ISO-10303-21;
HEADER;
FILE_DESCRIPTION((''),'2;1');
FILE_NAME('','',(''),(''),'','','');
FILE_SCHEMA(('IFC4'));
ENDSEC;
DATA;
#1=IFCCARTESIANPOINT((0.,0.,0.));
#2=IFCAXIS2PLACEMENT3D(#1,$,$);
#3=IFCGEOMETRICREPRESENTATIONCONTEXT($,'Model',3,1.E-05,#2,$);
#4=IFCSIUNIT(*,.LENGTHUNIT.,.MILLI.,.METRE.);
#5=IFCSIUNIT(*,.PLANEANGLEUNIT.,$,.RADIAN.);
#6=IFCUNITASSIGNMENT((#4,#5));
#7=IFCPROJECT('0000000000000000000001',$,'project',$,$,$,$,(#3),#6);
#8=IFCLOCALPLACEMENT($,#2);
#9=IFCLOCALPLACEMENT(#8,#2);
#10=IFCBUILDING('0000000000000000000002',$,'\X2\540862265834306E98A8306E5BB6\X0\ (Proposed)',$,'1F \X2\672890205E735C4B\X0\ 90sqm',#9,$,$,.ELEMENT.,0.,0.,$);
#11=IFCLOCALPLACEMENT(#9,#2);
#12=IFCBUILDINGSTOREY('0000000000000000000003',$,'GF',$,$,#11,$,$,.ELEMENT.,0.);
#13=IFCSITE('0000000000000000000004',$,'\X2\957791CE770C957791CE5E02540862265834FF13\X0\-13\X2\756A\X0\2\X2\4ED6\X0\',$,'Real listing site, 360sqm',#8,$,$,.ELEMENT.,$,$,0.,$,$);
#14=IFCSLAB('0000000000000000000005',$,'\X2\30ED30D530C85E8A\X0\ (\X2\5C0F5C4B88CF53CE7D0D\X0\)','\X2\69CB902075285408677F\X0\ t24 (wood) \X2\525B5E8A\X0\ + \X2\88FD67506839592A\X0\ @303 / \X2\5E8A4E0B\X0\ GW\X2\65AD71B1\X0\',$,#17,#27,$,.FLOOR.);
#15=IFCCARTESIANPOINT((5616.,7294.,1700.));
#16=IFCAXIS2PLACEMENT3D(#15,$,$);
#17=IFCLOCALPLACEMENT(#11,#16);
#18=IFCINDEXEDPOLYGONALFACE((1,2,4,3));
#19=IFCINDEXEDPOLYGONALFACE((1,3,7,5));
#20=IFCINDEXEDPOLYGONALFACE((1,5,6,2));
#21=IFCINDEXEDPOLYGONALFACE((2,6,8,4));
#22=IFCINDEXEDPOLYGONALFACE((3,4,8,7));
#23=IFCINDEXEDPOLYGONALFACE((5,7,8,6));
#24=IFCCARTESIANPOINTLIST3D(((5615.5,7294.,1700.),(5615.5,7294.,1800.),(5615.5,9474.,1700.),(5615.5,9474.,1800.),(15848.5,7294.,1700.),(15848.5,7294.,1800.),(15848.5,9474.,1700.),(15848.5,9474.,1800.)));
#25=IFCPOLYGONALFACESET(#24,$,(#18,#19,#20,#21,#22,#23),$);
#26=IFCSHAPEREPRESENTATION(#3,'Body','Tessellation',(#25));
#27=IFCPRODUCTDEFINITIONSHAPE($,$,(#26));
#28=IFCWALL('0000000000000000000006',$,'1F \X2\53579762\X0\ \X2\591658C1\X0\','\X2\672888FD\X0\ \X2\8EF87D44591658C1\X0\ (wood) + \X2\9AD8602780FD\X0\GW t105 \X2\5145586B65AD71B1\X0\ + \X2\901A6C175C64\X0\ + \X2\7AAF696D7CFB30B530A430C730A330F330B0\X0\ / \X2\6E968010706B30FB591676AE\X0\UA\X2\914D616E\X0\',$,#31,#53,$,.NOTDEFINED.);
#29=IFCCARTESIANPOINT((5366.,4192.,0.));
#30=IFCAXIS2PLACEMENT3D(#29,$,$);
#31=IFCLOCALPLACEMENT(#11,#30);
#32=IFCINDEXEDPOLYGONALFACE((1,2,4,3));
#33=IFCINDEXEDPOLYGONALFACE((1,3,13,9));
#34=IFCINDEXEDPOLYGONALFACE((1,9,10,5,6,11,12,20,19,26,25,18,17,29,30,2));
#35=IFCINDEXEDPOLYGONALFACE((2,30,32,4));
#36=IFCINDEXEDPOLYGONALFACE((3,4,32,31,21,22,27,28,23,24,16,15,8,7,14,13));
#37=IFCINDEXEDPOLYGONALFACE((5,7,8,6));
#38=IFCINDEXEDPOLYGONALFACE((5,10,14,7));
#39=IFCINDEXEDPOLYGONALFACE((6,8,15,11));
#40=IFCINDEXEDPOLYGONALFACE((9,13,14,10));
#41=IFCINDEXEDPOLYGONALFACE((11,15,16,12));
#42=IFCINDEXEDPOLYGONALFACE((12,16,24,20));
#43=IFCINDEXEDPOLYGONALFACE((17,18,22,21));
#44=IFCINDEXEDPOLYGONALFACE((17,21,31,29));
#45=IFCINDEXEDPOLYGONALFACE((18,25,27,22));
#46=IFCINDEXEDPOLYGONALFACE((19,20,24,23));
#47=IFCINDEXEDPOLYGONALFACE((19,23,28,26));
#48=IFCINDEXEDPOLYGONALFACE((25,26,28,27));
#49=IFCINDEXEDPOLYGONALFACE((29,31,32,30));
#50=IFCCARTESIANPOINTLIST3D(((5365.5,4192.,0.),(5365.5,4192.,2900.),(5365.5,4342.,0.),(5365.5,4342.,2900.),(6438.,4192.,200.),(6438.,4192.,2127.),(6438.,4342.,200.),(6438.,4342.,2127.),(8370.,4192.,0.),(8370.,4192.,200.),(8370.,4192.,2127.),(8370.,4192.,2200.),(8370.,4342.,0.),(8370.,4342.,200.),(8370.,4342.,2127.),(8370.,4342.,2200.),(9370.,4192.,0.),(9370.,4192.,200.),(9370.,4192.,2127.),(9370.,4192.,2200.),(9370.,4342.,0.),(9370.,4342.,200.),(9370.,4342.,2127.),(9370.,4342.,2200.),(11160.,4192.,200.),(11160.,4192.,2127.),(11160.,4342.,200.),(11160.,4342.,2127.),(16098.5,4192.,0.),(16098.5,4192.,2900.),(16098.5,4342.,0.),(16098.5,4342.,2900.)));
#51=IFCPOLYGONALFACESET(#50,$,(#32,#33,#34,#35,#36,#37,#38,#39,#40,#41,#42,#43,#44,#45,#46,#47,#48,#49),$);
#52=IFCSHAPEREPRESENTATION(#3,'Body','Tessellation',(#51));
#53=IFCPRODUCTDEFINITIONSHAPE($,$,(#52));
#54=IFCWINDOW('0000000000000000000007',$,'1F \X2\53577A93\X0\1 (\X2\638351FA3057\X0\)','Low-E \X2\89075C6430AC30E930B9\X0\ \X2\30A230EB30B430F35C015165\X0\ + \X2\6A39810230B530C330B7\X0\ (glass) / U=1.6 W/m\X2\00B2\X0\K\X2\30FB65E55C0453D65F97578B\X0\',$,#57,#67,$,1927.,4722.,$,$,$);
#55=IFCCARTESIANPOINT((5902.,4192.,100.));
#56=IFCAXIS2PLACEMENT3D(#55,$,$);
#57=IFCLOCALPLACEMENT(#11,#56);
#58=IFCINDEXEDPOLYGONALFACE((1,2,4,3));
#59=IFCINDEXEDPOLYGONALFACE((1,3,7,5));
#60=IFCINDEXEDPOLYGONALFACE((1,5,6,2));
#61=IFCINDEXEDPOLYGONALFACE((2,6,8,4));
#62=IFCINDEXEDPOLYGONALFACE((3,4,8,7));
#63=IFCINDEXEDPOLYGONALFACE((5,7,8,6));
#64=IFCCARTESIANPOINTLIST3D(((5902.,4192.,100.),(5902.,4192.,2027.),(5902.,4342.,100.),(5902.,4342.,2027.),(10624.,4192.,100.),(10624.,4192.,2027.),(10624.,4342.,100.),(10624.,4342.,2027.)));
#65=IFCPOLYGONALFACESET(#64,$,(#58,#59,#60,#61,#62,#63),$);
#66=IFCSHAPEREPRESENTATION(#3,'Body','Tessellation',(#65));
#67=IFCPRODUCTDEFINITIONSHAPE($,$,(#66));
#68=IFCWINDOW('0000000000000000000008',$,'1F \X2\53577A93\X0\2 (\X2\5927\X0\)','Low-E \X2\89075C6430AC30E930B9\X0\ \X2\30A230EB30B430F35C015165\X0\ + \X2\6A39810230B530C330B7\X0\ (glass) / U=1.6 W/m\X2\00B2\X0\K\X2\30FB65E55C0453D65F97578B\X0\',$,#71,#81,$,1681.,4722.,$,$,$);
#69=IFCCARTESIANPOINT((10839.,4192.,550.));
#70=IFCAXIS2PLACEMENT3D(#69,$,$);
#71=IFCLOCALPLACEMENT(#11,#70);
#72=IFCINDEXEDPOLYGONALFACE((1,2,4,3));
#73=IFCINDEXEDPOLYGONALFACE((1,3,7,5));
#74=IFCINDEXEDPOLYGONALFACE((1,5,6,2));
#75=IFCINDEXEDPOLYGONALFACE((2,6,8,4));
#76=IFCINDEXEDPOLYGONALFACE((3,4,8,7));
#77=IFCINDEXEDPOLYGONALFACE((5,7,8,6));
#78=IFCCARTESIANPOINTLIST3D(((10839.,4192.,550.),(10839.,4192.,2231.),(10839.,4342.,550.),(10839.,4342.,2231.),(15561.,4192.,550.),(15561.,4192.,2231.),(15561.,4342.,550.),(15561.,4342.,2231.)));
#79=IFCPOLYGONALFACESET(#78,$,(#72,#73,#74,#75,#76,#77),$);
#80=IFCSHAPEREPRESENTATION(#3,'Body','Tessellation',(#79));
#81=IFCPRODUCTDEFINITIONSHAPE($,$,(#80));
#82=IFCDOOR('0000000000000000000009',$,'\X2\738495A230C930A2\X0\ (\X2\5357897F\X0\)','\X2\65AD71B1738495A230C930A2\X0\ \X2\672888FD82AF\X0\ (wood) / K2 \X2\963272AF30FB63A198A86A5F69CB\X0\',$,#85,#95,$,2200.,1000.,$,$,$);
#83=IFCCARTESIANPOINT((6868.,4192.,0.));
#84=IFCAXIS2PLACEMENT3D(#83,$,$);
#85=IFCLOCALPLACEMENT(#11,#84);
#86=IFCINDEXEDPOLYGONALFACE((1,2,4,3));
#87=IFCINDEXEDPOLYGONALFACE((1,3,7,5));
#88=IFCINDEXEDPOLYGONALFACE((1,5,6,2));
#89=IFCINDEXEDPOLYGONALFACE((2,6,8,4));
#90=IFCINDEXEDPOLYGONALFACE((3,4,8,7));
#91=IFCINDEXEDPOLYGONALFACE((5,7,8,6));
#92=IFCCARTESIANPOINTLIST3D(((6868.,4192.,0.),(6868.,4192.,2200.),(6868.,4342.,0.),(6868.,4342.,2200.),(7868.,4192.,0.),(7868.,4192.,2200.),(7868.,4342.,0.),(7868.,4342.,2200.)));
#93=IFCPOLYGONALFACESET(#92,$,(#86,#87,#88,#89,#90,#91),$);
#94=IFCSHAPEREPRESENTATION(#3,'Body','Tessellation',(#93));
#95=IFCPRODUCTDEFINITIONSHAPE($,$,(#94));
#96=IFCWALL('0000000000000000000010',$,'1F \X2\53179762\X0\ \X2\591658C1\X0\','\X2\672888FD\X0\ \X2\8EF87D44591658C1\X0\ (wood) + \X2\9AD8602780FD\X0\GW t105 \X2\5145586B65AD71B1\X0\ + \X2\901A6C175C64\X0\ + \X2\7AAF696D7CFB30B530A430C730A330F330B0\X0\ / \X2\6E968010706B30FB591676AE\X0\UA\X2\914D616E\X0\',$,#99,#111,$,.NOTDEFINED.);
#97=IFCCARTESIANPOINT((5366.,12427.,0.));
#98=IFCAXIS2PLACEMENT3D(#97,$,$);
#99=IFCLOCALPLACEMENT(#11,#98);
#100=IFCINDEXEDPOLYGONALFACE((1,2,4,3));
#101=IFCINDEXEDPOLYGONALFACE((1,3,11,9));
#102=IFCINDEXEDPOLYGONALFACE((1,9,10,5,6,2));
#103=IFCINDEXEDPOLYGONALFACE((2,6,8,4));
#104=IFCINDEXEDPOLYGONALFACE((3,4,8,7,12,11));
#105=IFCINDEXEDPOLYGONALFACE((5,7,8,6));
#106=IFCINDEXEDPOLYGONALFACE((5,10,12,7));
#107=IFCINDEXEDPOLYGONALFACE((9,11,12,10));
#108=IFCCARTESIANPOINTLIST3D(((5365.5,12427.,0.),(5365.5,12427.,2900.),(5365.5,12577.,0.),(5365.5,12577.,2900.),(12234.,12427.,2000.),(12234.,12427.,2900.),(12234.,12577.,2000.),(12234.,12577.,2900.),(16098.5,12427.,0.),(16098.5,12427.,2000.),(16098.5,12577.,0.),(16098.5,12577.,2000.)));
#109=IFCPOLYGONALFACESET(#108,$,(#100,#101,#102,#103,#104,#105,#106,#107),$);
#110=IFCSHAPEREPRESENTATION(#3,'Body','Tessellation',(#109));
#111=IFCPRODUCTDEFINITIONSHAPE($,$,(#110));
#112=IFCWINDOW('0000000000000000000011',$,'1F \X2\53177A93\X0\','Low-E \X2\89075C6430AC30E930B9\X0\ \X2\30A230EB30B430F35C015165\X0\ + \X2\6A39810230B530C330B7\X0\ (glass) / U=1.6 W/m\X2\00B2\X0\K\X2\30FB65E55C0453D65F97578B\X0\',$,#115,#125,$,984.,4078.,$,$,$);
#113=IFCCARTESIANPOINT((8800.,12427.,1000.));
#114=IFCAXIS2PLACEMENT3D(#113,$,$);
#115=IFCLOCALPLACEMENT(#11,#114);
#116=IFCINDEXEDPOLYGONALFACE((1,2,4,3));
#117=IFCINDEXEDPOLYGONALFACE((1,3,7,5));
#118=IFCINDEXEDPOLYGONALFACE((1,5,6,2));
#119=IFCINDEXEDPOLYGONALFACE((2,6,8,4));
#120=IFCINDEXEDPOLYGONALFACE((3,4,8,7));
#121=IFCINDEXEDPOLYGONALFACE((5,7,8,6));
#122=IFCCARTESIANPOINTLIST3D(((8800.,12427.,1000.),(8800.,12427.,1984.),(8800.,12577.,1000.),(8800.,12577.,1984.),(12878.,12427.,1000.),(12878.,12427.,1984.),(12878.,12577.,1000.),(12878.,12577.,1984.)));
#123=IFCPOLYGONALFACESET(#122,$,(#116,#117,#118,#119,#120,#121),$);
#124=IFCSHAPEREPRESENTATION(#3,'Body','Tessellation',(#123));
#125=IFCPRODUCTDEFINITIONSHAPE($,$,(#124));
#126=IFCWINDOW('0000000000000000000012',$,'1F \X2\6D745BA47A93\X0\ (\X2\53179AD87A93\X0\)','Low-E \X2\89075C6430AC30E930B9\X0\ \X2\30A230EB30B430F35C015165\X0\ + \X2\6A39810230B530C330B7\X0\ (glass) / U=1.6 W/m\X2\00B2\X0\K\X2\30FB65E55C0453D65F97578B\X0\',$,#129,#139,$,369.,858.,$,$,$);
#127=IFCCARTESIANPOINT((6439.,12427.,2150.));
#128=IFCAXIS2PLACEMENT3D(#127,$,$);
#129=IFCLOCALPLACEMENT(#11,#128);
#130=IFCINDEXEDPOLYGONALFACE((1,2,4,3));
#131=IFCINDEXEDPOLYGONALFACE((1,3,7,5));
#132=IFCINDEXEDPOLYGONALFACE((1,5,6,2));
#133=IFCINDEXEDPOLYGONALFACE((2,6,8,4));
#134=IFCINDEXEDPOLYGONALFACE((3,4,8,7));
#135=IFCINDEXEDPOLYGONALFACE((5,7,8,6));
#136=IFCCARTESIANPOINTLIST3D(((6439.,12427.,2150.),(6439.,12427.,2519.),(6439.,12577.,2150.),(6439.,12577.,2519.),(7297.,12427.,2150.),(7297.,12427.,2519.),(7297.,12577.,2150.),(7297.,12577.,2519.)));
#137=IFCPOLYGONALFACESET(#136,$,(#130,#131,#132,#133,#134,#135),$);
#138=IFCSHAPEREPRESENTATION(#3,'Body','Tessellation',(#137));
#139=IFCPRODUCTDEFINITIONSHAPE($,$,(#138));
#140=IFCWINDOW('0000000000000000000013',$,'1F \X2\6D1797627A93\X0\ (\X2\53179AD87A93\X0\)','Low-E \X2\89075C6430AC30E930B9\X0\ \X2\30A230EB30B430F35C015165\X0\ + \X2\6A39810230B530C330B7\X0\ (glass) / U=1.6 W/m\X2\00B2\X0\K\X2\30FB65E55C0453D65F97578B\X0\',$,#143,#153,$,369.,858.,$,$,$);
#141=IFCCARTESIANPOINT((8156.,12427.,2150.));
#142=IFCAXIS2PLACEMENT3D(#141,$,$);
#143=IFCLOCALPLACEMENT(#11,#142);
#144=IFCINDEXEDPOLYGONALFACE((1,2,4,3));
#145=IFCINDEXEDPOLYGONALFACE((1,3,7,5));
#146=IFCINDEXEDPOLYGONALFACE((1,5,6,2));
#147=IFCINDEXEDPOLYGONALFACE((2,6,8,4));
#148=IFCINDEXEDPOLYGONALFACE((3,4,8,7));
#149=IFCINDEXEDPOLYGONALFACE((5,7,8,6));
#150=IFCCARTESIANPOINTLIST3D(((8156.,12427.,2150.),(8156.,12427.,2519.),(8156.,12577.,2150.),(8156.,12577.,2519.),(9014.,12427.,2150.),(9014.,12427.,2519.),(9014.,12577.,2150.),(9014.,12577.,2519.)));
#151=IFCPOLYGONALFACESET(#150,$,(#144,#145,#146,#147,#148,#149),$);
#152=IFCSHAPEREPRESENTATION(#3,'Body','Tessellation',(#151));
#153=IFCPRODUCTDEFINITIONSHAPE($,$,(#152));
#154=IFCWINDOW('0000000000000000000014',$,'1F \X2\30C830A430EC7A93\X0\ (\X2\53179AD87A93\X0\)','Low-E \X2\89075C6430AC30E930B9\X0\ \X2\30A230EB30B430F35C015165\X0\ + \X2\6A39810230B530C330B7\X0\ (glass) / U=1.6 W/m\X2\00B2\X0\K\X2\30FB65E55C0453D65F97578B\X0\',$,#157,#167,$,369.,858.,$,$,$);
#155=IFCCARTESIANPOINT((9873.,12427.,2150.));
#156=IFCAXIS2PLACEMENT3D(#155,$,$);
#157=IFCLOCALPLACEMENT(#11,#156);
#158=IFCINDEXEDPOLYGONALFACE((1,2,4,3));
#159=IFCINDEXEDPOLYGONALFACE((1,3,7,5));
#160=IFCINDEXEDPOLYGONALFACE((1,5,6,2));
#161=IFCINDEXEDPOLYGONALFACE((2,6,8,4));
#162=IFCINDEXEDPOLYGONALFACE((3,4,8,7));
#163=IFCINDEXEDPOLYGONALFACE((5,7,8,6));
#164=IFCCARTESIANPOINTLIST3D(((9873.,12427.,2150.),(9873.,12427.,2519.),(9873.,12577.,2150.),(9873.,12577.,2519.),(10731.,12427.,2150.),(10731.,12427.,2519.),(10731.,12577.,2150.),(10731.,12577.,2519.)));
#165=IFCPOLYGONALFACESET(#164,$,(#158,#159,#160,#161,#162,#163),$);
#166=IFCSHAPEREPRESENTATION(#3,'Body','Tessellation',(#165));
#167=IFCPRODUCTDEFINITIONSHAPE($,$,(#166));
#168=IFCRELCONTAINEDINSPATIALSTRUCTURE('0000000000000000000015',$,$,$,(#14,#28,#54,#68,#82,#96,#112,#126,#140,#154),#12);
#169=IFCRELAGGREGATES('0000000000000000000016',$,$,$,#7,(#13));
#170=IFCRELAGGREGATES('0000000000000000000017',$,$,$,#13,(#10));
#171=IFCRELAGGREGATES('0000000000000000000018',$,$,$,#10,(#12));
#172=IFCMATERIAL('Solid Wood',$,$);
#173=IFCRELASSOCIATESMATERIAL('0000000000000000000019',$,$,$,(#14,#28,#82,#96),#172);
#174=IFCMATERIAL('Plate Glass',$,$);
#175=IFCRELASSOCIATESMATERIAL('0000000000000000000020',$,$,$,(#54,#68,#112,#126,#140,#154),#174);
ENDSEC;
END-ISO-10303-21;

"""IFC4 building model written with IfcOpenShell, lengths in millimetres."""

from ifc_helpers import new_model, si_unit, frame, frame_2d, origin, place, context, project, spatial, rectangle, extrude, material, element, fill, save


model = new_model("IFC4")

# Units and contexts
model_context = context("Model", 3, precision=1e-05, world=origin())
ifc_project = project(units=[si_unit("LENGTHUNIT", "METRE", prefix="MILLI"), si_unit("PLANEANGLEUNIT", "RADIAN")], contexts=[model_context])

# Site, building, storey
site_placement = place(None, origin())
site = spatial("IfcSite", under=ifc_project, at=site_placement, Name="長野県長野市合戦場３-13番2他", ObjectType="Real listing site, 360sqm", CompositionType="ELEMENT", RefElevation=0.0)
building_placement = place(site_placement, origin())
building = spatial("IfcBuilding", under=site, at=building_placement, Name="合戦場の風の家 (Proposed)", ObjectType="1F 木造平屋 90sqm", CompositionType="ELEMENT", ElevationOfRefHeight=0.0, ElevationOfTerrain=0.0)
storey_placement = place(building_placement, origin())
storey = spatial("IfcBuildingStorey", under=building, at=storey_placement, Name="GF", CompositionType="ELEMENT", Elevation=0.0)

# Slab
ifc_material_1 = material(Name="Solid Wood")
slab_1_placement = place(storey_placement, frame((5616.0, 7294.0, 1700.0)))
element("IfcSlab", 1, at=slab_1_placement, inside=storey, material=ifc_material_1, Name="ロフト床 (小屋裏収納)", Description="構造用合板 t24 (wood) 剛床 + 製材根太 @303 / 床下 GW断熱", PredefinedType="FLOOR", context=model_context, shape_type="SweptSolid", body=[
    extrude(rectangle(XDim=10233.0, YDim=2180.0, at=frame_2d((5116.0, 1090.0))), frame((5616.0, 7294.0, 1700.0)), (0.0, 0.0, 1.0), 100.0),
])

# Wall, openings, windows, door
wall_1_placement = place(storey_placement, frame((5366.0, 4192.0, 0.0)))
wall_1 = element("IfcWall", 2, at=wall_1_placement, inside=storey, material=ifc_material_1, Name="1F 南面 外壁", Description="木製 軸組外壁 (wood) + 高性能GW t105 充填断熱 + 通気層 + 窯業系サイディング / 準耐火・外皮UA配慮", PredefinedType="NOTDEFINED", context=model_context, shape_type="SweptSolid", body=[
    extrude(rectangle(XDim=10733.0, YDim=150.0, at=frame_2d((5366.0, 75.0))), frame((5366.0, 4192.0, 0.0)), (0.0, 0.0, 1.0), 2900.0),
])
opening_1_placement = place(storey_placement, frame((5902.0, 4192.0, 100.0)))
opening_1 = element("IfcOpeningElement", 3, at=opening_1_placement, cuts=wall_1, PredefinedType="NOTDEFINED", context=model_context, shape_type="SweptSolid", body=[
    extrude(rectangle(XDim=4722.0, YDim=150.0, at=frame_2d((2361.0, 75.0))), frame((5902.0, 4192.0, 100.0)), (0.0, 0.0, 1.0), 1927.0),
])
opening_2_placement = place(storey_placement, frame((10839.0, 4192.0, 550.0)))
opening_2 = element("IfcOpeningElement", 4, at=opening_2_placement, cuts=wall_1, PredefinedType="NOTDEFINED", context=model_context, shape_type="SweptSolid", body=[
    extrude(rectangle(XDim=4722.0, YDim=150.0, at=frame_2d((2361.0, 75.0))), frame((10839.0, 4192.0, 550.0)), (0.0, 0.0, 1.0), 1681.0),
])
opening_3_placement = place(storey_placement, frame((6868.0, 4192.0, 0.0)))
opening_3 = element("IfcOpeningElement", 5, at=opening_3_placement, cuts=wall_1, PredefinedType="NOTDEFINED", context=model_context, shape_type="SweptSolid", body=[
    extrude(rectangle(XDim=1000.0, YDim=150.0, at=frame_2d((500.0, 75.0))), frame((6868.0, 4192.0, 0.0)), (0.0, 0.0, 1.0), 2200.0),
])
ifc_material_2 = material(Name="Plate Glass")
window_1_placement = place(storey_placement, frame((5902.0, 4192.0, 100.0)))
window_1 = element("IfcWindow", 6, at=window_1_placement, inside=storey, material=ifc_material_2, Name="1F 南窓1 (掃出し)", Description="Low-E 複層ガラス アルゴン封入 + 樹脂サッシ (glass) / U=1.6 W/m²K・日射取得型", OverallHeight=1927.0, OverallWidth=4722.0, context=model_context, shape_type="SweptSolid", body=[
    extrude(rectangle(XDim=4722.0, YDim=150.0, at=frame_2d((2361.0, 75.0))), frame((5902.0, 4192.0, 100.0)), (0.0, 0.0, 1.0), 1927.0),
])
fill(opening_1, window_1)
window_2_placement = place(storey_placement, frame((10839.0, 4192.0, 550.0)))
window_2 = element("IfcWindow", 7, at=window_2_placement, inside=storey, material=ifc_material_2, Name="1F 南窓2 (大)", Description="Low-E 複層ガラス アルゴン封入 + 樹脂サッシ (glass) / U=1.6 W/m²K・日射取得型", OverallHeight=1681.0, OverallWidth=4722.0, context=model_context, shape_type="SweptSolid", body=[
    extrude(rectangle(XDim=4722.0, YDim=150.0, at=frame_2d((2361.0, 75.0))), frame((10839.0, 4192.0, 550.0)), (0.0, 0.0, 1.0), 1681.0),
])
fill(opening_2, window_2)
door_1_placement = place(storey_placement, frame((6868.0, 4192.0, 0.0)))
door_1 = element("IfcDoor", 8, at=door_1_placement, inside=storey, material=ifc_material_1, Name="玄関ドア (南西)", Description="断熱玄関ドア 木製芯 (wood) / K2 防犯・採風機構", OverallHeight=2200.0, OverallWidth=1000.0, context=model_context, shape_type="SweptSolid", body=[
    extrude(rectangle(XDim=1000.0, YDim=150.0, at=frame_2d((500.0, 75.0))), frame((6868.0, 4192.0, 0.0)), (0.0, 0.0, 1.0), 2200.0),
])
fill(opening_3, door_1)

# Wall, openings, windows
wall_2_placement = place(storey_placement, frame((5366.0, 12427.0, 0.0)))
wall_2 = element("IfcWall", 9, at=wall_2_placement, inside=storey, material=ifc_material_1, Name="1F 北面 外壁", Description="木製 軸組外壁 (wood) + 高性能GW t105 充填断熱 + 通気層 + 窯業系サイディング / 準耐火・外皮UA配慮", PredefinedType="NOTDEFINED", context=model_context, shape_type="SweptSolid", body=[
    extrude(rectangle(XDim=10733.0, YDim=150.0, at=frame_2d((5366.0, 75.0))), frame((5366.0, 12427.0, 0.0)), (0.0, 0.0, 1.0), 2900.0),
])
opening_4_placement = place(storey_placement, frame((8800.0, 12427.0, 1000.0)))
opening_4 = element("IfcOpeningElement", 10, at=opening_4_placement, cuts=wall_2, PredefinedType="NOTDEFINED", context=model_context, shape_type="SweptSolid", body=[
    extrude(rectangle(XDim=4078.0, YDim=150.0, at=frame_2d((2039.0, 75.0))), frame((8800.0, 12427.0, 1000.0)), (0.0, 0.0, 1.0), 984.0),
])
opening_5_placement = place(storey_placement, frame((6439.0, 12427.0, 2150.0)))
opening_5 = element("IfcOpeningElement", 11, at=opening_5_placement, cuts=wall_2, PredefinedType="NOTDEFINED", context=model_context, shape_type="SweptSolid", body=[
    extrude(rectangle(XDim=858.0, YDim=150.0, at=frame_2d((429.0, 75.0))), frame((6439.0, 12427.0, 2150.0)), (0.0, 0.0, 1.0), 369.0),
])
opening_6_placement = place(storey_placement, frame((8156.0, 12427.0, 2150.0)))
opening_6 = element("IfcOpeningElement", 12, at=opening_6_placement, cuts=wall_2, PredefinedType="NOTDEFINED", context=model_context, shape_type="SweptSolid", body=[
    extrude(rectangle(XDim=858.0, YDim=150.0, at=frame_2d((429.0, 75.0))), frame((8156.0, 12427.0, 2150.0)), (0.0, 0.0, 1.0), 369.0),
])
opening_7_placement = place(storey_placement, frame((9873.0, 12427.0, 2150.0)))
opening_7 = element("IfcOpeningElement", 13, at=opening_7_placement, cuts=wall_2, PredefinedType="NOTDEFINED", context=model_context, shape_type="SweptSolid", body=[
    extrude(rectangle(XDim=858.0, YDim=150.0, at=frame_2d((429.0, 75.0))), frame((9873.0, 12427.0, 2150.0)), (0.0, 0.0, 1.0), 369.0),
])
window_3_placement = place(storey_placement, frame((8800.0, 12427.0, 1000.0)))
window_3 = element("IfcWindow", 14, at=window_3_placement, inside=storey, material=ifc_material_2, Name="1F 北窓", Description="Low-E 複層ガラス アルゴン封入 + 樹脂サッシ (glass) / U=1.6 W/m²K・日射取得型", OverallHeight=984.0, OverallWidth=4078.0, context=model_context, shape_type="SweptSolid", body=[
    extrude(rectangle(XDim=4078.0, YDim=150.0, at=frame_2d((2039.0, 75.0))), frame((8800.0, 12427.0, 1000.0)), (0.0, 0.0, 1.0), 984.0),
])
fill(opening_4, window_3)
window_4_placement = place(storey_placement, frame((6439.0, 12427.0, 2150.0)))
window_4 = element("IfcWindow", 15, at=window_4_placement, inside=storey, material=ifc_material_2, Name="1F 浴室窓 (北高窓)", Description="Low-E 複層ガラス アルゴン封入 + 樹脂サッシ (glass) / U=1.6 W/m²K・日射取得型", OverallHeight=369.0, OverallWidth=858.0, context=model_context, shape_type="SweptSolid", body=[
    extrude(rectangle(XDim=858.0, YDim=150.0, at=frame_2d((429.0, 75.0))), frame((6439.0, 12427.0, 2150.0)), (0.0, 0.0, 1.0), 369.0),
])
fill(opening_5, window_4)
window_5_placement = place(storey_placement, frame((8156.0, 12427.0, 2150.0)))
window_5 = element("IfcWindow", 16, at=window_5_placement, inside=storey, material=ifc_material_2, Name="1F 洗面窓 (北高窓)", Description="Low-E 複層ガラス アルゴン封入 + 樹脂サッシ (glass) / U=1.6 W/m²K・日射取得型", OverallHeight=369.0, OverallWidth=858.0, context=model_context, shape_type="SweptSolid", body=[
    extrude(rectangle(XDim=858.0, YDim=150.0, at=frame_2d((429.0, 75.0))), frame((8156.0, 12427.0, 2150.0)), (0.0, 0.0, 1.0), 369.0),
])
fill(opening_6, window_5)
window_6_placement = place(storey_placement, frame((9873.0, 12427.0, 2150.0)))
window_6 = element("IfcWindow", 17, at=window_6_placement, inside=storey, material=ifc_material_2, Name="1F トイレ窓 (北高窓)", Description="Low-E 複層ガラス アルゴン封入 + 樹脂サッシ (glass) / U=1.6 W/m²K・日射取得型", OverallHeight=369.0, OverallWidth=858.0, context=model_context, shape_type="SweptSolid", body=[
    extrude(rectangle(XDim=858.0, YDim=150.0, at=frame_2d((429.0, 75.0))), frame((9873.0, 12427.0, 2150.0)), (0.0, 0.0, 1.0), 369.0),
])
fill(opening_7, window_6)

save(model, "model.ifc")
